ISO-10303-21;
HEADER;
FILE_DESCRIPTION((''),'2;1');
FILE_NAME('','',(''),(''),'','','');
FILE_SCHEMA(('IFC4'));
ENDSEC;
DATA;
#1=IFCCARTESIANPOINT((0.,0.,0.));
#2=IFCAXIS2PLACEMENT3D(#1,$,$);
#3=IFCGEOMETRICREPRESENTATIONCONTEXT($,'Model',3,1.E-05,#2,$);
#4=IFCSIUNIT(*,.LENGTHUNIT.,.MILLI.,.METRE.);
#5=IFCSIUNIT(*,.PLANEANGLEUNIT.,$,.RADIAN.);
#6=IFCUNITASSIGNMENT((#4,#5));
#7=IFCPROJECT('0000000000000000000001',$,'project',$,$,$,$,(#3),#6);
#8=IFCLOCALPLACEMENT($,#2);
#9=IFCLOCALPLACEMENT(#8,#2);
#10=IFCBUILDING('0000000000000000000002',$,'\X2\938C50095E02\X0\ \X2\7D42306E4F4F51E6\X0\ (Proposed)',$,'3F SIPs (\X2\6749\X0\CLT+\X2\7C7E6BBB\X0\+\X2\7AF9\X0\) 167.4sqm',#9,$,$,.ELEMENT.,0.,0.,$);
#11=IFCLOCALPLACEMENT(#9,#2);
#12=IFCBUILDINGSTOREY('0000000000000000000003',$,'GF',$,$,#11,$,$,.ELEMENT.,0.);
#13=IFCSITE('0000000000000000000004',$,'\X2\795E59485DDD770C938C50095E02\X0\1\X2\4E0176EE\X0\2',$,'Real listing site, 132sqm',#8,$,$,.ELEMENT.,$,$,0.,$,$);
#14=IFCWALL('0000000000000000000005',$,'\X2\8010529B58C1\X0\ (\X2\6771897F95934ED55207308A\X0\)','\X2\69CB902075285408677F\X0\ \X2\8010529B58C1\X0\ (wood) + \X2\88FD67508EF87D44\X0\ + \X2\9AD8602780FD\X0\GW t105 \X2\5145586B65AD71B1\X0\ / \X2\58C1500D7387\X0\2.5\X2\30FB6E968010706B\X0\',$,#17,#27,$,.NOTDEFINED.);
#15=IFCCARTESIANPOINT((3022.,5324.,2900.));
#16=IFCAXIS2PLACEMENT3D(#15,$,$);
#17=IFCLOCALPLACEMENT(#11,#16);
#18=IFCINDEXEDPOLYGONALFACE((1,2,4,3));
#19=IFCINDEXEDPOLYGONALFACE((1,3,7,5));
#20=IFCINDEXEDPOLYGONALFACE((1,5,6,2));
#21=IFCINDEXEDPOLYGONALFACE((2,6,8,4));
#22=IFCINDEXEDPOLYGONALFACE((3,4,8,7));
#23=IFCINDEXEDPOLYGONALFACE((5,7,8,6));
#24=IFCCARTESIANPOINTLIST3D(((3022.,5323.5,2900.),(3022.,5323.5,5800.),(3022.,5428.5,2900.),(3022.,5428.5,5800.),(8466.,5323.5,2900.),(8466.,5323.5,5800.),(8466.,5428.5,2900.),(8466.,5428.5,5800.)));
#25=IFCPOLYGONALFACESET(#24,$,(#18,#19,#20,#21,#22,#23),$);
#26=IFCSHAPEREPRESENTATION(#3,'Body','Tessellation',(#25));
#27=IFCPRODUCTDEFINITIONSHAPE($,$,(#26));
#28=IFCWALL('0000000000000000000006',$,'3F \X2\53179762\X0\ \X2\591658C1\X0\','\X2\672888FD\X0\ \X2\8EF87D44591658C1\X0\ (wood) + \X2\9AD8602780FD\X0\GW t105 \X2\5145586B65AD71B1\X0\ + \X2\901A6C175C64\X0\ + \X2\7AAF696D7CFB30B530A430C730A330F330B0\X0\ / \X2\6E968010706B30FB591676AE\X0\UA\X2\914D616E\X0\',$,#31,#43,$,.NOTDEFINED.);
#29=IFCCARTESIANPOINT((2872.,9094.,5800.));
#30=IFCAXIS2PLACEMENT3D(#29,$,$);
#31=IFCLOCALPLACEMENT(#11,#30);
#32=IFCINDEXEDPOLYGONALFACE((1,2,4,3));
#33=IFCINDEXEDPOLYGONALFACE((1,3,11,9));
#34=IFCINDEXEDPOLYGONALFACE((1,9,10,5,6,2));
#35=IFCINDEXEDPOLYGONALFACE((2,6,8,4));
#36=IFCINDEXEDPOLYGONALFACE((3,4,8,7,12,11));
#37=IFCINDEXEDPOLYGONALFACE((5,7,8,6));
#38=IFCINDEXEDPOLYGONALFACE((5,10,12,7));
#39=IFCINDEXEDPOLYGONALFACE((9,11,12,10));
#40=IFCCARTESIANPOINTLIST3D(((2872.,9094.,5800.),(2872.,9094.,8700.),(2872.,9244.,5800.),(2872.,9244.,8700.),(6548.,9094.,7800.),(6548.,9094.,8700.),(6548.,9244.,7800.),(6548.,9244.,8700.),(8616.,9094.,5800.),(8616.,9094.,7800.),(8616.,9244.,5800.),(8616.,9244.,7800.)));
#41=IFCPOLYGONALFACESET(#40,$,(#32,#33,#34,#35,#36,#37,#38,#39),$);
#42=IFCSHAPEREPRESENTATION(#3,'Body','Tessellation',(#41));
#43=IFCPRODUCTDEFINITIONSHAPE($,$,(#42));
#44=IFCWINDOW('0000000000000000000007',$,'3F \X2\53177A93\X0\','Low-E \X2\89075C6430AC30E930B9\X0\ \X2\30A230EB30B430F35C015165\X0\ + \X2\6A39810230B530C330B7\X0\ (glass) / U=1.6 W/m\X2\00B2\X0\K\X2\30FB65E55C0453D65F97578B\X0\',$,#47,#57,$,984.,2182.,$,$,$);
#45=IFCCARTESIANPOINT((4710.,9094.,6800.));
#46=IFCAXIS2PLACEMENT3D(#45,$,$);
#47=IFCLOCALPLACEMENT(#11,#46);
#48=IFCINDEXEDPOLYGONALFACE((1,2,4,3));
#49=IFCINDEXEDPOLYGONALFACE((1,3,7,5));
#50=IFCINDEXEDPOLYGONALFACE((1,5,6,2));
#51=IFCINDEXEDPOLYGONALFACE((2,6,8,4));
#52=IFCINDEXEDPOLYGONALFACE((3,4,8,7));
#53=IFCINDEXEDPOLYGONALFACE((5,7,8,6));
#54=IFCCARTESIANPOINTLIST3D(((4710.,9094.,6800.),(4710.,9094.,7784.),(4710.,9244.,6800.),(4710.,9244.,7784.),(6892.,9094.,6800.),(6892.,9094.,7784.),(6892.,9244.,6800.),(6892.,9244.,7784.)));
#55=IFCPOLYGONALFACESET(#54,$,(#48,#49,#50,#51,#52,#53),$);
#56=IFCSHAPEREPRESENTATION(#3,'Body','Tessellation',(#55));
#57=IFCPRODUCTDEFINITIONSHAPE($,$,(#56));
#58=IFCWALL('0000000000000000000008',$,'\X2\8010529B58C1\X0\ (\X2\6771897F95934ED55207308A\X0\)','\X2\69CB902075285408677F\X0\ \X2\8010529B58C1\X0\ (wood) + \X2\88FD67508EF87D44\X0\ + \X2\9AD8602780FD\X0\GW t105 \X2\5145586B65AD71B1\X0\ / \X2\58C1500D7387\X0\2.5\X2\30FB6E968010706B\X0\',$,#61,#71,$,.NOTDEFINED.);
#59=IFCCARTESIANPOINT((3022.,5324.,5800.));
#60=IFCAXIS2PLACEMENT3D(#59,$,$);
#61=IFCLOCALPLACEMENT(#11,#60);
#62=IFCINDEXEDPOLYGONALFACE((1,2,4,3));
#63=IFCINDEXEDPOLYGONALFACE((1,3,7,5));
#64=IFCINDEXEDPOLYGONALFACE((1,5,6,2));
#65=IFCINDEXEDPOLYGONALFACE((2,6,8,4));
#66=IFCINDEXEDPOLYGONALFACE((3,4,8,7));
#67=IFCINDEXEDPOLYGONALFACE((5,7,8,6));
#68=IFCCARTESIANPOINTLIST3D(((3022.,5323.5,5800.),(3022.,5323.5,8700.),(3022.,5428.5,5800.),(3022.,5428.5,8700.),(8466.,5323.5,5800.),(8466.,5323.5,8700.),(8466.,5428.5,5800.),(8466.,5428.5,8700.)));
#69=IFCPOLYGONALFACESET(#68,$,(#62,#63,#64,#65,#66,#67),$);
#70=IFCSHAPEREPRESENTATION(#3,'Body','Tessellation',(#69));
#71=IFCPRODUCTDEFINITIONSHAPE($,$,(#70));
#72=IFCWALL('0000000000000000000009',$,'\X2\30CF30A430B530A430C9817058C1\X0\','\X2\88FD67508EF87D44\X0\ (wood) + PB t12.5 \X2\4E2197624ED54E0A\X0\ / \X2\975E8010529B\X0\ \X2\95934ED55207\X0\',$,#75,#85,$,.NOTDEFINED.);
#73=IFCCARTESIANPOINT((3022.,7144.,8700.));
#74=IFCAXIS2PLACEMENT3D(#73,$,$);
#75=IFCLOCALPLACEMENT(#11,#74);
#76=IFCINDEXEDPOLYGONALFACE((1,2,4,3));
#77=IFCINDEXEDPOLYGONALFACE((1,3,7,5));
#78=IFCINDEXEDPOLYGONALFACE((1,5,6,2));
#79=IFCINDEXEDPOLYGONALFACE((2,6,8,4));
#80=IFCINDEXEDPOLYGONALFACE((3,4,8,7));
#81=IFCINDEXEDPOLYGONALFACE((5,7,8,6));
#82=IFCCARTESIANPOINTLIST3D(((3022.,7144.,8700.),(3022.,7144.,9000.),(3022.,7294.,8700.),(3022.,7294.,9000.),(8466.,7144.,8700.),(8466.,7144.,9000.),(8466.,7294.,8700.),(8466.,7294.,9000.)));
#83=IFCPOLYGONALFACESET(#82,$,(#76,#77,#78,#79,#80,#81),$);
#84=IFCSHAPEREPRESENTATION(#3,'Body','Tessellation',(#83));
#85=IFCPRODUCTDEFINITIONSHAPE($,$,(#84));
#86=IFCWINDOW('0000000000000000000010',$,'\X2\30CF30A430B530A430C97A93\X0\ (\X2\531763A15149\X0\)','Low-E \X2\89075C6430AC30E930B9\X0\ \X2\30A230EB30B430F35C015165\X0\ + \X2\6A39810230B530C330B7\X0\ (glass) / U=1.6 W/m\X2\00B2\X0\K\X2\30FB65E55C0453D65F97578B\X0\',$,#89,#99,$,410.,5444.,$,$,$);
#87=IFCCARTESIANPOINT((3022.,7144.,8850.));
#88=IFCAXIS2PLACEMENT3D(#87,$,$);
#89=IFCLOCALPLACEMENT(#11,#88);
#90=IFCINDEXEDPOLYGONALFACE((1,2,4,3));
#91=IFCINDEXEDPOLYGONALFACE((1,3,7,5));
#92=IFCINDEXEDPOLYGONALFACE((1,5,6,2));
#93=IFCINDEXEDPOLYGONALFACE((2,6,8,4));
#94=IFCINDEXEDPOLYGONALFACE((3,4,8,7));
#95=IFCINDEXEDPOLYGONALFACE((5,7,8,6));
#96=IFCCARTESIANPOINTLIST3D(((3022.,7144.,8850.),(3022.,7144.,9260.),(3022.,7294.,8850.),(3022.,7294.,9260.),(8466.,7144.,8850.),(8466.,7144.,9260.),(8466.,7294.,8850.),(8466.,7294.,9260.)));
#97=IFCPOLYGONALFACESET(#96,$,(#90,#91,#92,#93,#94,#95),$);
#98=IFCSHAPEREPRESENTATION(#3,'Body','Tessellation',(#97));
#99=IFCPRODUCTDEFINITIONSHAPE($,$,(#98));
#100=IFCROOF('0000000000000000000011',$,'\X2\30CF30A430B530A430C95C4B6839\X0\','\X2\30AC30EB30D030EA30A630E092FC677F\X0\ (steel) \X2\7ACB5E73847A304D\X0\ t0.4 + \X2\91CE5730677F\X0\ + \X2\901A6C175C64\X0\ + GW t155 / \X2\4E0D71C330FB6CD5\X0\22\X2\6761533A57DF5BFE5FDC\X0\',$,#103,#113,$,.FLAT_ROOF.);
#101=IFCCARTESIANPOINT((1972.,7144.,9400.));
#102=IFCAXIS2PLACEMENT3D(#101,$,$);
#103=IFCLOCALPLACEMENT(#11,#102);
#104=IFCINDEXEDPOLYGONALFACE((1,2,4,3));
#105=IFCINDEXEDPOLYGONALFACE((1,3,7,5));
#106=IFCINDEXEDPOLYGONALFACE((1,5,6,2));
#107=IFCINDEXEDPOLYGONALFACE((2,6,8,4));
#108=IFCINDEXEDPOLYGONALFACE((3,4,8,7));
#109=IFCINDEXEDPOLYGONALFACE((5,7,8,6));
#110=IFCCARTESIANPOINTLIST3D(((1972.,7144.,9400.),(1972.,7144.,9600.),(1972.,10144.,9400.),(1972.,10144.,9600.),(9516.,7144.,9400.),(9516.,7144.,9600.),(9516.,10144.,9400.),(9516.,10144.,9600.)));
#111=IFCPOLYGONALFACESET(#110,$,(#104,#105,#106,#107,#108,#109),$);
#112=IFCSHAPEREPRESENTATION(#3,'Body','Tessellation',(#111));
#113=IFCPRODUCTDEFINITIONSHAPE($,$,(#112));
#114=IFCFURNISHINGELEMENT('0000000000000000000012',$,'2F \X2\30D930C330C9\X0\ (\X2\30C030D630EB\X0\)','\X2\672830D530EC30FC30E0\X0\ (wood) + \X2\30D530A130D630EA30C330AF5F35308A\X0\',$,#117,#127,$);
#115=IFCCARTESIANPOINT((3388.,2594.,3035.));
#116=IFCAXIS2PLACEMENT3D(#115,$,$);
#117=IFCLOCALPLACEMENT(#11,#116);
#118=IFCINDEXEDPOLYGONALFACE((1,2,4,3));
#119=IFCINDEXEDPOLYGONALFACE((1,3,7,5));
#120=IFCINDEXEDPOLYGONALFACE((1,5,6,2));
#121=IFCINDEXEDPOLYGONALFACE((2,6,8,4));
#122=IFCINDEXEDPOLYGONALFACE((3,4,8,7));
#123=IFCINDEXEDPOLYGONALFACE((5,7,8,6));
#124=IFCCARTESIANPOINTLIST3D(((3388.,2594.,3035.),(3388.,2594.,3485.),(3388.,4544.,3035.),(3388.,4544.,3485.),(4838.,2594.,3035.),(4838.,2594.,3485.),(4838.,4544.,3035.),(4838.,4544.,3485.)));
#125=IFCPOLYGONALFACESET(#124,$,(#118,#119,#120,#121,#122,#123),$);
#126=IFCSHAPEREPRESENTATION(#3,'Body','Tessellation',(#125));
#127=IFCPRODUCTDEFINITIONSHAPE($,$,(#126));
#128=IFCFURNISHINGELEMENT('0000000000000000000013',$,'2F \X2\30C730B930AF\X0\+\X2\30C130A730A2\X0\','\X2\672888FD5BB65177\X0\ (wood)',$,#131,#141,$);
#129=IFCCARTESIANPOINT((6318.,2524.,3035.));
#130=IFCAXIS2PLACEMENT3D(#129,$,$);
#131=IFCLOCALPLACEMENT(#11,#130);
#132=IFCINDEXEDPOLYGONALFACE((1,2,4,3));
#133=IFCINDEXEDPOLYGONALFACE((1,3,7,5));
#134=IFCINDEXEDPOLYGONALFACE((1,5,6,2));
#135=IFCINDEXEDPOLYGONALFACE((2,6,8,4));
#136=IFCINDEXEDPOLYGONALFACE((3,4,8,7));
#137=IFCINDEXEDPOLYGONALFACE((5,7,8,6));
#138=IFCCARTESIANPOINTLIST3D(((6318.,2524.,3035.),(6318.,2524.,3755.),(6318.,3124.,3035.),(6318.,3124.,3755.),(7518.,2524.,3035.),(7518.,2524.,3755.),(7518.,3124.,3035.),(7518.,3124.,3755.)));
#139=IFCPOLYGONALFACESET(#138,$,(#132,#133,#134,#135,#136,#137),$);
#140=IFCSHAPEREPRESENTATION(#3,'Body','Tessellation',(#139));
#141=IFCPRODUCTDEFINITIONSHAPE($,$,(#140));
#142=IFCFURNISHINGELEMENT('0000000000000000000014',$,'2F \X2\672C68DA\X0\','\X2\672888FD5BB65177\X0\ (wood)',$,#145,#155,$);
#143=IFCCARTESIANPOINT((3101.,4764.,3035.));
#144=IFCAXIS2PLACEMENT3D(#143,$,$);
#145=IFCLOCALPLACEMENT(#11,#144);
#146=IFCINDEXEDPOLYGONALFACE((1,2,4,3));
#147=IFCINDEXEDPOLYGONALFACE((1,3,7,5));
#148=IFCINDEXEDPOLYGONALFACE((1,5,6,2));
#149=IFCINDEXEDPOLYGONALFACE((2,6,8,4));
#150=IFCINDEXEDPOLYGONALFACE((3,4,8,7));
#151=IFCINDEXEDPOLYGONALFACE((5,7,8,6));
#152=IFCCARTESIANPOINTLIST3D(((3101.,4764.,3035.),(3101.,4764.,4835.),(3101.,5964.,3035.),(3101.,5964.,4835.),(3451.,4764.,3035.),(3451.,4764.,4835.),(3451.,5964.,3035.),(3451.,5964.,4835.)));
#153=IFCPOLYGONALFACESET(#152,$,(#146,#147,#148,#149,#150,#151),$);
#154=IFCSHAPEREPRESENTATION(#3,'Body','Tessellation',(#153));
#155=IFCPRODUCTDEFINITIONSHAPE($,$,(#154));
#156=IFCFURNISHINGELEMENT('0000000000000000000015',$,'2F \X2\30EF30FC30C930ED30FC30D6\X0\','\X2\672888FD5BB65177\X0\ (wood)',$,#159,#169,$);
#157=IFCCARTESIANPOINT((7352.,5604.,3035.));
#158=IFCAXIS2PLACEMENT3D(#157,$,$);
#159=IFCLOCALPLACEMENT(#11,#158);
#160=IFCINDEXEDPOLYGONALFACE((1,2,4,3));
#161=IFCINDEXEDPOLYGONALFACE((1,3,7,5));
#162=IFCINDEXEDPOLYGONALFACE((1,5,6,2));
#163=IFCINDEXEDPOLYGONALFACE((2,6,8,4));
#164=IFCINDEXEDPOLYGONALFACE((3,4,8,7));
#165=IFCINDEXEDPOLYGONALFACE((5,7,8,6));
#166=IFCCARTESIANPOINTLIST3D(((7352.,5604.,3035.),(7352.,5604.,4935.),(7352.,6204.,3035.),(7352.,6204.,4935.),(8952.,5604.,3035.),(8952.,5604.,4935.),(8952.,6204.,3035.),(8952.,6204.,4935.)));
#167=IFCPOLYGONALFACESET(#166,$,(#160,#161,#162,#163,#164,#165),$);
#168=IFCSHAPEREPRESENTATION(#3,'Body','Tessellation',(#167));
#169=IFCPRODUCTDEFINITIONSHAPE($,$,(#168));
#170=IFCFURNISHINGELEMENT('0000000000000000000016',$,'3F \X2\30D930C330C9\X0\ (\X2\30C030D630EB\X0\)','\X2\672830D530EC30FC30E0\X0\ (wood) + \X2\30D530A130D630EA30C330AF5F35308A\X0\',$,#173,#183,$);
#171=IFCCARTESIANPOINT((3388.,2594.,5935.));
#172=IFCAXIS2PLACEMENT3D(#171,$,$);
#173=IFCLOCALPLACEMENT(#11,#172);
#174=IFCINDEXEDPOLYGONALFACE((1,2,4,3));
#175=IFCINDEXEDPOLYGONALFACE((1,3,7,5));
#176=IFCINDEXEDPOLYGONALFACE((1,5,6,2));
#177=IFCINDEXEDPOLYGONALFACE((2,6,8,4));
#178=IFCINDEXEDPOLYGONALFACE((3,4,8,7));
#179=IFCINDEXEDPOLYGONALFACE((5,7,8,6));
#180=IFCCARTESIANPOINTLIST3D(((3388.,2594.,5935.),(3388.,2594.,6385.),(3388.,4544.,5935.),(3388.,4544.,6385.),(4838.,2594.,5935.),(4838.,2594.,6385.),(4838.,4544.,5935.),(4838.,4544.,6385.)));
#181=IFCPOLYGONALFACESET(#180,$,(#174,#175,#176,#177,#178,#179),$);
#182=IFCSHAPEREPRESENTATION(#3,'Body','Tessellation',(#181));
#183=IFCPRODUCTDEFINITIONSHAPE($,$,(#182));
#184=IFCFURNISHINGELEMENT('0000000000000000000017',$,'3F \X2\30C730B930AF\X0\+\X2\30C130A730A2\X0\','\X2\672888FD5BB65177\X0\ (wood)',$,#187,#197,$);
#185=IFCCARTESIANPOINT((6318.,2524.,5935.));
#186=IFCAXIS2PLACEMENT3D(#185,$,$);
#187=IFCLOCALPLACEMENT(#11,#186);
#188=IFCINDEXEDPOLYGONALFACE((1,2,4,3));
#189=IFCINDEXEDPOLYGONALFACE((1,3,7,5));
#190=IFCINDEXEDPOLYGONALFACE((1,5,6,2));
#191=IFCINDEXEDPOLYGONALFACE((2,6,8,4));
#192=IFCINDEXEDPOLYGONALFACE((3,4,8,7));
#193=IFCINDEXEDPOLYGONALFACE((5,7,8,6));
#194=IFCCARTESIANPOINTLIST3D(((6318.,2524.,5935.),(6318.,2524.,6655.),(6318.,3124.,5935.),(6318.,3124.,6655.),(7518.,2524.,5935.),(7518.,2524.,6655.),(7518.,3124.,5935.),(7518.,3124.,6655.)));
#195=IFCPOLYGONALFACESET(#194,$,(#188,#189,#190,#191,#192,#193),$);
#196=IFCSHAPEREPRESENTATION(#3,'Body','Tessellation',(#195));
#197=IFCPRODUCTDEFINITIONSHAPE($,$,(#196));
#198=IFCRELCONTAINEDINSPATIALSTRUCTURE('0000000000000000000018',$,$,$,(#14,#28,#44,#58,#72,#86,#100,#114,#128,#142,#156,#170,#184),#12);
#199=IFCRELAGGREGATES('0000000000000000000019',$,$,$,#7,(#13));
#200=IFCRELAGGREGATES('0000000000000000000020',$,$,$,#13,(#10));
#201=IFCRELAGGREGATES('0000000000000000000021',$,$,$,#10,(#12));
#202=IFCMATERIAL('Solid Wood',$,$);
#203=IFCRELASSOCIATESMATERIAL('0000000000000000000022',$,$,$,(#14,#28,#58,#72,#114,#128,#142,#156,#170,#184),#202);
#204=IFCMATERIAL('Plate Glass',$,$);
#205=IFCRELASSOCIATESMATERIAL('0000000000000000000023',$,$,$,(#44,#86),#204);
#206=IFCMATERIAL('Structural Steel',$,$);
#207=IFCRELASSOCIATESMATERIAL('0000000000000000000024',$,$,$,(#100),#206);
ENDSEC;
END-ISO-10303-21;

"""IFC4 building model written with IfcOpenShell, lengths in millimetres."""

from ifc_helpers import new_model, si_unit, frame, frame_2d, origin, place, context, project, spatial, rectangle, extrude, material, element, fill, save


model = new_model("IFC4")

# Units and contexts
model_context = context("Model", 3, precision=1e-05, world=origin())
ifc_project = project(units=[si_unit("LENGTHUNIT", "METRE", prefix="MILLI"), si_unit("PLANEANGLEUNIT", "RADIAN")], contexts=[model_context])

# Site, building, storey
site_placement = place(None, origin())
site = spatial("IfcSite", under=ifc_project, at=site_placement, Name="神奈川県鎌倉市1丁目2", ObjectType="Real listing site, 132sqm", CompositionType="ELEMENT", RefElevation=0.0)
building_placement = place(site_placement, origin())
building = spatial("IfcBuilding", under=site, at=building_placement, Name="鎌倉市 終の住処 (Proposed)", ObjectType="3F SIPs (杉CLT+籾殻+竹) 167.4sqm", CompositionType="ELEMENT", ElevationOfRefHeight=0.0, ElevationOfTerrain=0.0)
storey_placement = place(building_placement, origin())
storey = spatial("IfcBuildingStorey", under=building, at=storey_placement, Name="GF", CompositionType="ELEMENT", Elevation=0.0)

# Wall
ifc_material_1 = material(Name="Solid Wood")
wall_1_placement = place(storey_placement, frame((3022.0, 5324.0, 2900.0)))
element("IfcWall", 1, at=wall_1_placement, inside=storey, material=ifc_material_1, Name="耐力壁 (東西間仕切り)", Description="構造用合板 耐力壁 (wood) + 製材軸組 + 高性能GW t105 充填断熱 / 壁倍率2.5・準耐火", PredefinedType="NOTDEFINED", context=model_context, shape_type="SweptSolid", body=[
    extrude(rectangle(XDim=5444.0, YDim=105.0, at=frame_2d((2722.0, 52.0))), frame((3022.0, 5324.0, 2900.0)), (0.0, 0.0, 1.0), 2900.0),
])

# Wall, opening, window
wall_2_placement = place(storey_placement, frame((2872.0, 9094.0, 5800.0)))
wall_2 = element("IfcWall", 2, at=wall_2_placement, inside=storey, material=ifc_material_1, Name="3F 北面 外壁", Description="木製 軸組外壁 (wood) + 高性能GW t105 充填断熱 + 通気層 + 窯業系サイディング / 準耐火・外皮UA配慮", PredefinedType="NOTDEFINED", context=model_context, shape_type="SweptSolid", body=[
    extrude(rectangle(XDim=5744.0, YDim=150.0, at=frame_2d((2872.0, 75.0))), frame((2872.0, 9094.0, 5800.0)), (0.0, 0.0, 1.0), 2900.0),
])
opening_1_placement = place(storey_placement, frame((4710.0, 9094.0, 6800.0)))
opening_1 = element("IfcOpeningElement", 3, at=opening_1_placement, cuts=wall_2, PredefinedType="NOTDEFINED", context=model_context, shape_type="SweptSolid", body=[
    extrude(rectangle(XDim=2182.0, YDim=150.0, at=frame_2d((1091.0, 75.0))), frame((4710.0, 9094.0, 6800.0)), (0.0, 0.0, 1.0), 984.0),
])
ifc_material_2 = material(Name="Plate Glass")
window_1_placement = place(storey_placement, frame((4710.0, 9094.0, 6800.0)))
window_1 = element("IfcWindow", 4, at=window_1_placement, inside=storey, material=ifc_material_2, Name="3F 北窓", Description="Low-E 複層ガラス アルゴン封入 + 樹脂サッシ (glass) / U=1.6 W/m²K・日射取得型", OverallHeight=984.0, OverallWidth=2182.0, context=model_context, shape_type="SweptSolid", body=[
    extrude(rectangle(XDim=2182.0, YDim=150.0, at=frame_2d((1091.0, 75.0))), frame((4710.0, 9094.0, 6800.0)), (0.0, 0.0, 1.0), 984.0),
])
fill(opening_1, window_1)

# Wall
wall_3_placement = place(storey_placement, frame((3022.0, 5324.0, 5800.0)))
element("IfcWall", 5, at=wall_3_placement, inside=storey, material=ifc_material_1, Name="耐力壁 (東西間仕切り)", Description="構造用合板 耐力壁 (wood) + 製材軸組 + 高性能GW t105 充填断熱 / 壁倍率2.5・準耐火", PredefinedType="NOTDEFINED", context=model_context, shape_type="SweptSolid", body=[
    extrude(rectangle(XDim=5444.0, YDim=105.0, at=frame_2d((2722.0, 52.0))), frame((3022.0, 5324.0, 5800.0)), (0.0, 0.0, 1.0), 2900.0),
])

# Wall, opening, window
wall_4_placement = place(storey_placement, frame((3022.0, 7144.0, 8700.0)))
wall_4 = element("IfcWall", 6, at=wall_4_placement, inside=storey, material=ifc_material_1, Name="ハイサイド腰壁", Description="製材軸組 (wood) + PB t12.5 両面仕上 / 非耐力 間仕切", PredefinedType="NOTDEFINED", context=model_context, shape_type="SweptSolid", body=[
    extrude(rectangle(XDim=5444.0, YDim=150.0, at=frame_2d((2722.0, 75.0))), frame((3022.0, 7144.0, 8700.0)), (0.0, 0.0, 1.0), 700.0),
])
opening_2_placement = place(storey_placement, frame((3022.0, 7144.0, 8850.0)))
opening_2 = element("IfcOpeningElement", 7, at=opening_2_placement, cuts=wall_4, PredefinedType="NOTDEFINED", context=model_context, shape_type="SweptSolid", body=[
    extrude(rectangle(XDim=5444.0, YDim=150.0, at=frame_2d((2722.0, 75.0))), frame((3022.0, 7144.0, 8850.0)), (0.0, 0.0, 1.0), 410.0),
])
window_2_placement = place(storey_placement, frame((3022.0, 7144.0, 8850.0)))
window_2 = element("IfcWindow", 8, at=window_2_placement, inside=storey, material=ifc_material_2, Name="ハイサイド窓 (北採光)", Description="Low-E 複層ガラス アルゴン封入 + 樹脂サッシ (glass) / U=1.6 W/m²K・日射取得型", OverallHeight=410.0, OverallWidth=5444.0, context=model_context, shape_type="SweptSolid", body=[
    extrude(rectangle(XDim=5444.0, YDim=150.0, at=frame_2d((2722.0, 75.0))), frame((3022.0, 7144.0, 8850.0)), (0.0, 0.0, 1.0), 410.0),
])
fill(opening_2, window_2)

# Roof
ifc_material_3 = material(Name="Structural Steel")
roof_placement = place(storey_placement, frame((1972.0, 7144.0, 9400.0)))
element("IfcRoof", 9, at=roof_placement, inside=storey, material=ifc_material_3, Name="ハイサイド屋根", Description="ガルバリウム鋼板 (steel) 立平葺き t0.4 + 野地板 + 通気層 + GW t155 / 不燃・法22条区域対応", PredefinedType="FLAT_ROOF", context=model_context, shape_type="SweptSolid", body=[
    extrude(rectangle(XDim=7544.0, YDim=3000.0, at=frame_2d((3772.0, 1500.0))), frame((1972.0, 7144.0, 9400.0)), (0.0, 0.0, 1.0), 200.0),
])

# Furnishing elements
furnishing_1_placement = place(storey_placement, frame((3388.0, 2594.0, 3035.0)))
element("IfcFurnishingElement", 10, at=furnishing_1_placement, inside=storey, material=ifc_material_1, Name="2F ベッド (ダブル)", Description="木フレーム (wood) + ファブリック張り", context=model_context, shape_type="SweptSolid", body=[
    extrude(rectangle(XDim=1450.0, YDim=1950.0, at=frame_2d((725.0, 975.0))), frame((3388.0, 2594.0, 3035.0)), (0.0, 0.0, 1.0), 450.0),
])
furnishing_2_placement = place(storey_placement, frame((6318.0, 2524.0, 3035.0)))
element("IfcFurnishingElement", 11, at=furnishing_2_placement, inside=storey, material=ifc_material_1, Name="2F デスク+チェア", Description="木製家具 (wood)", context=model_context, shape_type="SweptSolid", body=[
    extrude(rectangle(XDim=1200.0, YDim=600.0, at=frame_2d((600.0, 300.0))), frame((6318.0, 2524.0, 3035.0)), (0.0, 0.0, 1.0), 720.0),
])
furnishing_3_placement = place(storey_placement, frame((3101.0, 4764.0, 3035.0)))
element("IfcFurnishingElement", 12, at=furnishing_3_placement, inside=storey, material=ifc_material_1, Name="2F 本棚", Description="木製家具 (wood)", context=model_context, shape_type="SweptSolid", body=[
    extrude(rectangle(XDim=350.0, YDim=1200.0, at=frame_2d((175.0, 600.0))), frame((3101.0, 4764.0, 3035.0)), (0.0, 0.0, 1.0), 1800.0),
])
furnishing_4_placement = place(storey_placement, frame((7352.0, 5604.0, 3035.0)))
element("IfcFurnishingElement", 13, at=furnishing_4_placement, inside=storey, material=ifc_material_1, Name="2F ワードローブ", Description="木製家具 (wood)", context=model_context, shape_type="SweptSolid", body=[
    extrude(rectangle(XDim=1600.0, YDim=600.0, at=frame_2d((800.0, 300.0))), frame((7352.0, 5604.0, 3035.0)), (0.0, 0.0, 1.0), 1900.0),
])
furnishing_5_placement = place(storey_placement, frame((3388.0, 2594.0, 5935.0)))
element("IfcFurnishingElement", 14, at=furnishing_5_placement, inside=storey, material=ifc_material_1, Name="3F ベッド (ダブル)", Description="木フレーム (wood) + ファブリック張り", context=model_context, shape_type="SweptSolid", body=[
    extrude(rectangle(XDim=1450.0, YDim=1950.0, at=frame_2d((725.0, 975.0))), frame((3388.0, 2594.0, 5935.0)), (0.0, 0.0, 1.0), 450.0),
])
furnishing_6_placement = place(storey_placement, frame((6318.0, 2524.0, 5935.0)))
element("IfcFurnishingElement", 15, at=furnishing_6_placement, inside=storey, material=ifc_material_1, Name="3F デスク+チェア", Description="木製家具 (wood)", context=model_context, shape_type="SweptSolid", body=[
    extrude(rectangle(XDim=1200.0, YDim=600.0, at=frame_2d((600.0, 300.0))), frame((6318.0, 2524.0, 5935.0)), (0.0, 0.0, 1.0), 720.0),
])

save(model, "model.ifc")
